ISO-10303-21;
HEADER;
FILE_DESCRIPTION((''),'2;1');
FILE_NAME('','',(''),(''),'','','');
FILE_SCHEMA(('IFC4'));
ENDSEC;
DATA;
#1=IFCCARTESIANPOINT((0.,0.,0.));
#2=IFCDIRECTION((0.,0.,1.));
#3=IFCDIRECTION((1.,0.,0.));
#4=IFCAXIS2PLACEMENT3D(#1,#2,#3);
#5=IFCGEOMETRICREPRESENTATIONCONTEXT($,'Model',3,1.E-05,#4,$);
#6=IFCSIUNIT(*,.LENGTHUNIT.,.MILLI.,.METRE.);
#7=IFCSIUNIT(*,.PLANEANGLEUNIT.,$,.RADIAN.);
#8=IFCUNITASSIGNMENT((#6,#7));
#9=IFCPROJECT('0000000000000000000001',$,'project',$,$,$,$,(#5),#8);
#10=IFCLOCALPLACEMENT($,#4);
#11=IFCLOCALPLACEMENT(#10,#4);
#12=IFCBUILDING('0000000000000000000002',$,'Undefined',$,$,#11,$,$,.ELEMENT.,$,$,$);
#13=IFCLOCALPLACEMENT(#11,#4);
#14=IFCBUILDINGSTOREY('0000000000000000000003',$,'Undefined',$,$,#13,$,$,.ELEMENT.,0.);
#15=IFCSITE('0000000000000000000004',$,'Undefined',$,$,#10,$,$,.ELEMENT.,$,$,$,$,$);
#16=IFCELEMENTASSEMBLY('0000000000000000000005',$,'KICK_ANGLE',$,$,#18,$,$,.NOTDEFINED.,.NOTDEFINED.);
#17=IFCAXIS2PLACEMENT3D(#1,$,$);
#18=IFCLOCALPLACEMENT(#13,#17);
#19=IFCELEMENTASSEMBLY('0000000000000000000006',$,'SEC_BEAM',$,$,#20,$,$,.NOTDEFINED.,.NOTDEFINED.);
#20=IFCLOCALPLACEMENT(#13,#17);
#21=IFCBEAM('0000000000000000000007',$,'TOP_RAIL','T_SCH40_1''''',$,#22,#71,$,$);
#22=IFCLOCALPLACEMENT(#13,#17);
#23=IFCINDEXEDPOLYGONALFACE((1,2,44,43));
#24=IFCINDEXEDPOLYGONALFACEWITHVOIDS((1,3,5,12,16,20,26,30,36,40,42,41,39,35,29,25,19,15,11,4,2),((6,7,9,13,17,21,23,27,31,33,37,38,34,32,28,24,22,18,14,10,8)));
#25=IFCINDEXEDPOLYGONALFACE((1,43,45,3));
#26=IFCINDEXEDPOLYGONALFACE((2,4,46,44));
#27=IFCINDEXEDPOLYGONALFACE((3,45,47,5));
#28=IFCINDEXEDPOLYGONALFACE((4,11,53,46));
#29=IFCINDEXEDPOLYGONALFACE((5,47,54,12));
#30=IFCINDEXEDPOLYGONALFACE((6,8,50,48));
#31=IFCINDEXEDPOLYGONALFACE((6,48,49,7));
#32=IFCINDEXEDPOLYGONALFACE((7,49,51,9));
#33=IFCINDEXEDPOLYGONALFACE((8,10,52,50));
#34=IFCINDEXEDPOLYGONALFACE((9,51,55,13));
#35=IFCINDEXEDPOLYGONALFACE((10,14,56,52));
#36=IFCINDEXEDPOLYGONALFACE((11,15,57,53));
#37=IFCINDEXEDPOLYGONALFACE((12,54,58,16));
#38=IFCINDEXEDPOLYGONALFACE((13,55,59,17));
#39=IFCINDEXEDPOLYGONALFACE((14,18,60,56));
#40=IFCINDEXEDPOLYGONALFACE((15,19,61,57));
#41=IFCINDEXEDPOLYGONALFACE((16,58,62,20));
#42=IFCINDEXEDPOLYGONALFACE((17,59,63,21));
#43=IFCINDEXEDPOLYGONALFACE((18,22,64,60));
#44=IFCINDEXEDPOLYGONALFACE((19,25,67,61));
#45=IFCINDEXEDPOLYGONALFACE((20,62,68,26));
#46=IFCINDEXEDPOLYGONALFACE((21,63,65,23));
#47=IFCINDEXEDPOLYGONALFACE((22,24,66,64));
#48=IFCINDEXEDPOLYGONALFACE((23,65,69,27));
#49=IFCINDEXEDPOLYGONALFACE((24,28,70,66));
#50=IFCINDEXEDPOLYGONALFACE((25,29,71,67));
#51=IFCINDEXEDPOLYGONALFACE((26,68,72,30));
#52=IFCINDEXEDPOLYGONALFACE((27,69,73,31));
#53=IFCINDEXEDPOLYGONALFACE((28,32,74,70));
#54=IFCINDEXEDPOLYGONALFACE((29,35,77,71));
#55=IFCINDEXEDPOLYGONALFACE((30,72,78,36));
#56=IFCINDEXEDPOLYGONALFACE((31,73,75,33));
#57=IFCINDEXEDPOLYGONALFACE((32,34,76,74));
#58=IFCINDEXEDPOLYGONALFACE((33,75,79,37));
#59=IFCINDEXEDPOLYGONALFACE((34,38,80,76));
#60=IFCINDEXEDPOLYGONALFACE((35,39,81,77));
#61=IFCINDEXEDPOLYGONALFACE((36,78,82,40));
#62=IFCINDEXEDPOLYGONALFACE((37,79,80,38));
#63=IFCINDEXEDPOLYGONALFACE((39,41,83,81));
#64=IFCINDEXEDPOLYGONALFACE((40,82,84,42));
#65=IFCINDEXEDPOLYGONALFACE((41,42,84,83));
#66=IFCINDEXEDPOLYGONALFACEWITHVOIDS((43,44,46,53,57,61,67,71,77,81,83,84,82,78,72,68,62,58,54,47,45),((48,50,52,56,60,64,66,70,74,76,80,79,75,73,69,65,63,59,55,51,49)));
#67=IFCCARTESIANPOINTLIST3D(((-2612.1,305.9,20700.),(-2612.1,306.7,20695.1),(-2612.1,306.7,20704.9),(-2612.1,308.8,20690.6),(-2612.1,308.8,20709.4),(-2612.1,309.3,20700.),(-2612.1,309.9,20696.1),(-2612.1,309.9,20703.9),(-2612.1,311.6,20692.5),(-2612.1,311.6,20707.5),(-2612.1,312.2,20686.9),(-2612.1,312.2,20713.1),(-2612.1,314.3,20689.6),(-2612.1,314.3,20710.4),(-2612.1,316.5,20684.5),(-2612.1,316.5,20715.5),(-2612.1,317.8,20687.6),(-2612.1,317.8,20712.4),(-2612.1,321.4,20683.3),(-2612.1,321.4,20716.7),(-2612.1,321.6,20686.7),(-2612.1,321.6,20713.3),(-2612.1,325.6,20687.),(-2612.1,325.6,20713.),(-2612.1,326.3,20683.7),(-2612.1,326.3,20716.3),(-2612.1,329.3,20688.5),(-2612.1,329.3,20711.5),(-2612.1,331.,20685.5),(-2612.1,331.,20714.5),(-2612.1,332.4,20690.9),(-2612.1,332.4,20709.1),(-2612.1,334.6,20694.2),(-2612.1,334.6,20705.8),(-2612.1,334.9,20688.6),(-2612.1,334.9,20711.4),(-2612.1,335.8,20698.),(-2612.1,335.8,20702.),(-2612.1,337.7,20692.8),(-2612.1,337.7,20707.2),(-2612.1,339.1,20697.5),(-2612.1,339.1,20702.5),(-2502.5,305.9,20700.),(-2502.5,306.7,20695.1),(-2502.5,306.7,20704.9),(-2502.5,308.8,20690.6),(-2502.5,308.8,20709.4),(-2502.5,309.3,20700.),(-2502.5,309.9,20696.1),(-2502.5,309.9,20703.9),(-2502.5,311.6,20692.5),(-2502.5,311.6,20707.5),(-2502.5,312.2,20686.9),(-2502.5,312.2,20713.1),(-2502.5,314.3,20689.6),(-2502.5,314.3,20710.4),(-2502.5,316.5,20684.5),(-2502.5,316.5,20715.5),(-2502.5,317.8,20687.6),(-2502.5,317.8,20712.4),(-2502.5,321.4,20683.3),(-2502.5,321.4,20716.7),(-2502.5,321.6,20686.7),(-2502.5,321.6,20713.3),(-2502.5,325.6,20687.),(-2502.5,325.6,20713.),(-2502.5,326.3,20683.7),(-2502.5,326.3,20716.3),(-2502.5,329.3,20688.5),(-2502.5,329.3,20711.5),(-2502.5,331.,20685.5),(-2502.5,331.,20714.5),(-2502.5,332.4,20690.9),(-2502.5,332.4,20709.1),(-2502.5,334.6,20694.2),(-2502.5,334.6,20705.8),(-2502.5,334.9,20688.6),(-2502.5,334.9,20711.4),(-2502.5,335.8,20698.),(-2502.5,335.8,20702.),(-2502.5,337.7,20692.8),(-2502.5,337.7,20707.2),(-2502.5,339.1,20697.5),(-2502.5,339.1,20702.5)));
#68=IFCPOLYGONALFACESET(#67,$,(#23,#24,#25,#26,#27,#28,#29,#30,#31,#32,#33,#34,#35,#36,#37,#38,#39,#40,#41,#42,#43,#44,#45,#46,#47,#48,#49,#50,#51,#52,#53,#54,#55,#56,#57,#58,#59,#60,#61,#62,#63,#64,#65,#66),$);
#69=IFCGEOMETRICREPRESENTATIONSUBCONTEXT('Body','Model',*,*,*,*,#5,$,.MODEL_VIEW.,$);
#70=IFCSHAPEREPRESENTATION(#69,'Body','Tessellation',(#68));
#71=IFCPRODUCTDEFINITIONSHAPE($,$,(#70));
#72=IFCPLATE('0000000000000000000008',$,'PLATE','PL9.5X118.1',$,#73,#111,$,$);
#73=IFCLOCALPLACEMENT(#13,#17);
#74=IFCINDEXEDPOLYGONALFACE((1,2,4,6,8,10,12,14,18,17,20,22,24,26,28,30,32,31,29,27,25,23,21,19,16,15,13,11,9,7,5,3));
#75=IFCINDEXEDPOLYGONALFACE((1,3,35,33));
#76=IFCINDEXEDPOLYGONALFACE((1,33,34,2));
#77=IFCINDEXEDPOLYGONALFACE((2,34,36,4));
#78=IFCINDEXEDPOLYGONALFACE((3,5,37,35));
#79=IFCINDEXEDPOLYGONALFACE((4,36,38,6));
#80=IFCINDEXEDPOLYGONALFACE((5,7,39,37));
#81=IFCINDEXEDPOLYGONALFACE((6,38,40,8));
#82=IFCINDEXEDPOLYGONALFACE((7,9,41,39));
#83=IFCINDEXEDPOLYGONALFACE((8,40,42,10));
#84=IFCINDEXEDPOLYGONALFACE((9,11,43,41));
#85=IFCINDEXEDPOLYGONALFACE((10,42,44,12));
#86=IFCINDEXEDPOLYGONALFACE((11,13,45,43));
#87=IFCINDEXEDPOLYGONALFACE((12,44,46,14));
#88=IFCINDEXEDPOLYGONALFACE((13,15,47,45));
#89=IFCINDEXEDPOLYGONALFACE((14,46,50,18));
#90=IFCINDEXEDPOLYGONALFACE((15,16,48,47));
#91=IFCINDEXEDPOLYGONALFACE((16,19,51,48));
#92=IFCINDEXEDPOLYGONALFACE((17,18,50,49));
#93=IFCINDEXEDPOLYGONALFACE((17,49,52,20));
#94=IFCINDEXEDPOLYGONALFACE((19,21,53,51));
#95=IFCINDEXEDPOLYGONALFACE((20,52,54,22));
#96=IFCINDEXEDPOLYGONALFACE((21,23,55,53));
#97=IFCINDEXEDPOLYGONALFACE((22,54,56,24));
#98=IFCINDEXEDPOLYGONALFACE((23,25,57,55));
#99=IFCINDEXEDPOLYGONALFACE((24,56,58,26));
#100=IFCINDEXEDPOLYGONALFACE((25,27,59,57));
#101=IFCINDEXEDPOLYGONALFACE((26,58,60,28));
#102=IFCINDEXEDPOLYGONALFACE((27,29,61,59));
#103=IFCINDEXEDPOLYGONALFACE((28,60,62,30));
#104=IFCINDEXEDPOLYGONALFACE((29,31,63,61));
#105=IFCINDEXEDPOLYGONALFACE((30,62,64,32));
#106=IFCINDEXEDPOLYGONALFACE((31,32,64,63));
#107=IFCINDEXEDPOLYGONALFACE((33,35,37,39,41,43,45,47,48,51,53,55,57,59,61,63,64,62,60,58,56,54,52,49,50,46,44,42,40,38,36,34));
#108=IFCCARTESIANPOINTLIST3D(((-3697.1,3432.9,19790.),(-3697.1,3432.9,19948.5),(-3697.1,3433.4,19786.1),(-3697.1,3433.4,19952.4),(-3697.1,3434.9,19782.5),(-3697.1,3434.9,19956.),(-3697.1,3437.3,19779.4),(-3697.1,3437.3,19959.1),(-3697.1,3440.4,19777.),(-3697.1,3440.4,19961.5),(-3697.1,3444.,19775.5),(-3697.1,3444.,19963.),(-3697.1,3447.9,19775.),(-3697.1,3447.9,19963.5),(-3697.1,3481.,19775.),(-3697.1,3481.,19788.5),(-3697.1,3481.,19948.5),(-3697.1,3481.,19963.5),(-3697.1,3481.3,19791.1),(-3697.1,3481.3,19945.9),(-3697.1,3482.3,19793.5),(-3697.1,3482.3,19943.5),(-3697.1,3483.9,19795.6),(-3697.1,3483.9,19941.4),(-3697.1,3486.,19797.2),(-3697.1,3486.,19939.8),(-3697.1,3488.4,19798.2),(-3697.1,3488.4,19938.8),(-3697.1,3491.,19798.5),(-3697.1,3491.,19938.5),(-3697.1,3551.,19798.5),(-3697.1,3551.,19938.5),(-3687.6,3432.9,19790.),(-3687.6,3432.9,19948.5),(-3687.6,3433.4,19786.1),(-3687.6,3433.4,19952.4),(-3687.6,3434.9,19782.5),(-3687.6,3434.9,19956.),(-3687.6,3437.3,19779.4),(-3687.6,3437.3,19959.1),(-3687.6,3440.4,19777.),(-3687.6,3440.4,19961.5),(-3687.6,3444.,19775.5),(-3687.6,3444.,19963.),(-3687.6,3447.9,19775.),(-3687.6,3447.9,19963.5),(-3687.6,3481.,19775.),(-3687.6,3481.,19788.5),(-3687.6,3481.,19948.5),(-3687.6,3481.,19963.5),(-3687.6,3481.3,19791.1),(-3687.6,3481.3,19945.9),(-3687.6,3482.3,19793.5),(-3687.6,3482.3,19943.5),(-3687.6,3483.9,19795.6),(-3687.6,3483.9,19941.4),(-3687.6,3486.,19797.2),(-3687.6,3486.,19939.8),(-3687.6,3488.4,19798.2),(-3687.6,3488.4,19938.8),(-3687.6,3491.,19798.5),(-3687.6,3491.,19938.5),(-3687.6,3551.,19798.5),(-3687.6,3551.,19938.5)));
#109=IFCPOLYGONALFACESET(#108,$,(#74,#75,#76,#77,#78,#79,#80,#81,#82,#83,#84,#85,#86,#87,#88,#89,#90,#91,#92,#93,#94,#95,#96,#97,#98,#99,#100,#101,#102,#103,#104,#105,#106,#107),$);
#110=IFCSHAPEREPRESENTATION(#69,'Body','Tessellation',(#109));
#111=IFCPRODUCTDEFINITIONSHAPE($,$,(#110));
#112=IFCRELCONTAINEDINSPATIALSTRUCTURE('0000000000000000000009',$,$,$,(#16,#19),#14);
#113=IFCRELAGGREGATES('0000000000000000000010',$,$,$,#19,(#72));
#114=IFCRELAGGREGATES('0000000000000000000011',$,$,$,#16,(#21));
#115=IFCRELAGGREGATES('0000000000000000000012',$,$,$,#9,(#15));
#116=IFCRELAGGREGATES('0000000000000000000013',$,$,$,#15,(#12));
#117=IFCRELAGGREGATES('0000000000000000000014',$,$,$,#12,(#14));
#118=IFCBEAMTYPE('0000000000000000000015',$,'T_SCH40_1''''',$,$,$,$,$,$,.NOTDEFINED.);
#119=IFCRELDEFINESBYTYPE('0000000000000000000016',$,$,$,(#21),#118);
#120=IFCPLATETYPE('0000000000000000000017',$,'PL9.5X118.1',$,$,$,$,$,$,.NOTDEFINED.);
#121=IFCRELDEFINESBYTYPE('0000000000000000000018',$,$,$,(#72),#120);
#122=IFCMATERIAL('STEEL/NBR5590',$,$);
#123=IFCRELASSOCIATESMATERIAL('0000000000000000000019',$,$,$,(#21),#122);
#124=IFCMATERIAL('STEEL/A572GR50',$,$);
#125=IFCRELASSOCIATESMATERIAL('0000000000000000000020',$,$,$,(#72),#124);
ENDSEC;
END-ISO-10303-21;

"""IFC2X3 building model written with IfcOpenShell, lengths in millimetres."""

from ifc_helpers import new_model, si_unit, frame, frame_2d, origin_with_axes, origin_2d_with_axis, place, context, subcontext, project, spatial, polyline, circle_curve, parameter, trimmed, segment, composite_curve, hollow_circle, outline, extrude, clip, halfspace, material, type_object, element, aggregate, save


model = new_model("IFC2X3")

# Units and contexts
model_context = context("Model", 3, precision=1e-05, world=origin_with_axes())
body_context = subcontext(model_context, "Body", "Model", "MODEL_VIEW")
ifc_project = project(units=[si_unit("LENGTHUNIT", "METRE", prefix="MILLI"), si_unit("PLANEANGLEUNIT", "RADIAN")], contexts=[model_context])

# Site, building, storey
site_placement = place(None, origin_with_axes())
site = spatial("IfcSite", under=ifc_project, at=site_placement, Name="Undefined", CompositionType="ELEMENT")
building_placement = place(site_placement, origin_with_axes())
building = spatial("IfcBuilding", under=site, at=building_placement, Name="Undefined", CompositionType="ELEMENT")
storey_placement = place(building_placement, origin_with_axes())
storey = spatial("IfcBuildingStorey", under=building, at=storey_placement, Name="Undefined", CompositionType="ELEMENT", Elevation=0.0)

# Shared definitions
ifc_material_1 = material(Name="STEEL/A572GR50")

# Element assembly
ifc_material_2 = material(Name="STEEL/NBR5590")
assembly_1_placement = place(storey_placement, origin_with_axes())
assembly_1 = element("IfcElementAssembly", 1, at=assembly_1_placement, inside=storey, Name="KICK_ANGLE", AssemblyPlace="NOTDEFINED", PredefinedType="NOTDEFINED")

# Element assembly
assembly_2_placement = place(storey_placement, origin_with_axes())
assembly_2 = element("IfcElementAssembly", 2, at=assembly_2_placement, inside=storey, Name="SEC_BEAM", AssemblyPlace="NOTDEFINED", PredefinedType="NOTDEFINED")

# Beam
beam_type_1 = type_object("IfcBeamType", Name="T_SCH40_1''", PredefinedType="NOTDEFINED")
beam_1_placement = place(assembly_1_placement, frame((-2612.1, 322.6, 20700.0), z_axis=(0.0, 0.0, 1.0), x_axis=(1.0, -0.000013, 0.0)))
beam_1 = element("IfcBeam", 3, at=beam_1_placement, type_object=beam_type_1, material=ifc_material_2, Name="TOP_RAIL", Description="T_SCH40_1''", context=body_context, shape_type="Clipping", body=[
    clip(extrude(hollow_circle(Radius=16.7, WallThickness=3.4, at=origin_2d_with_axis()), frame((109.6, 0.0, 0.0), z_axis=(-1.0, 0.0, 0.0), x_axis=(0.0, -1.0, 0.0)), (0.0, 0.0, 1.0), 109.6), halfspace(frame((109.6, 0.0, 0.0), z_axis=(1.0, 0.0, 0.0), x_axis=(0.0, -1.0, 0.0)), False)),
])

# Plate
plate_type = type_object("IfcPlateType", Name="PL9.5X118.1", PredefinedType="NOTDEFINED")
plate_placement = place(assembly_2_placement, frame((-3692.4, 3432.9, 19963.5), z_axis=(1.0, 0.0, 0.0), x_axis=(0.0, 0.0, -1.0)))
plate = element("IfcPlate", 4, at=plate_placement, type_object=plate_type, material=ifc_material_1, Name="PLATE", Description="PL9.5X118.1", context=body_context, shape_type="SweptSolid", body=[
    extrude(outline(composite_curve([segment(trimmed(circle_curve(frame_2d((15.0, 15.0), x_axis=(-1.0, 0.0)), 15.0), [parameter(0.0)], [parameter(1.570796)], True, "PARAMETER"), True, "CONTINUOUS"), segment(polyline([(15.0, 0.0), (173.5, 0.0)]), True, "CONTINUOUS"), segment(trimmed(circle_curve(frame_2d((173.5, 15.0), x_axis=(0.0, -1.0)), 15.0), [parameter(0.0)], [parameter(1.570796)], True, "PARAMETER"), True, "CONTINUOUS"), segment(polyline([(188.5, 15.0), (188.5, 48.1), (175.0, 48.1)]), True, "CONTINUOUS"), segment(trimmed(circle_curve(frame_2d((175.0, 58.1), x_axis=(0.0, -1.0)), 10.0), [parameter(0.0)], [parameter(4.712389)], False, "PARAMETER"), True, "CONTINUOUS"), segment(polyline([(165.0, 58.1), (165.0, 118.1), (25.0, 118.1), (25.0, 58.1)]), True, "CONTINUOUS"), segment(trimmed(circle_curve(frame_2d((15.0, 58.1), x_axis=(1.0, 0.0)), 10.0), [parameter(0.0)], [parameter(4.712389)], False, "PARAMETER"), True, "CONTINUOUS"), segment(polyline([(15.0, 48.1), (0.0, 48.1), (0.0, 15.0)]), True, "CONTINUOUS")], self_intersect=True)), frame((0.0, 0.0, -4.8), z_axis=(0.0, 0.0, 1.0), x_axis=(1.0, 0.0, 0.0)), (0.0, 0.0, 1.0), 9.5),
])

aggregate(assembly_2, [plate])
aggregate(assembly_1, [beam_1])

save(model, "model.ifc")
